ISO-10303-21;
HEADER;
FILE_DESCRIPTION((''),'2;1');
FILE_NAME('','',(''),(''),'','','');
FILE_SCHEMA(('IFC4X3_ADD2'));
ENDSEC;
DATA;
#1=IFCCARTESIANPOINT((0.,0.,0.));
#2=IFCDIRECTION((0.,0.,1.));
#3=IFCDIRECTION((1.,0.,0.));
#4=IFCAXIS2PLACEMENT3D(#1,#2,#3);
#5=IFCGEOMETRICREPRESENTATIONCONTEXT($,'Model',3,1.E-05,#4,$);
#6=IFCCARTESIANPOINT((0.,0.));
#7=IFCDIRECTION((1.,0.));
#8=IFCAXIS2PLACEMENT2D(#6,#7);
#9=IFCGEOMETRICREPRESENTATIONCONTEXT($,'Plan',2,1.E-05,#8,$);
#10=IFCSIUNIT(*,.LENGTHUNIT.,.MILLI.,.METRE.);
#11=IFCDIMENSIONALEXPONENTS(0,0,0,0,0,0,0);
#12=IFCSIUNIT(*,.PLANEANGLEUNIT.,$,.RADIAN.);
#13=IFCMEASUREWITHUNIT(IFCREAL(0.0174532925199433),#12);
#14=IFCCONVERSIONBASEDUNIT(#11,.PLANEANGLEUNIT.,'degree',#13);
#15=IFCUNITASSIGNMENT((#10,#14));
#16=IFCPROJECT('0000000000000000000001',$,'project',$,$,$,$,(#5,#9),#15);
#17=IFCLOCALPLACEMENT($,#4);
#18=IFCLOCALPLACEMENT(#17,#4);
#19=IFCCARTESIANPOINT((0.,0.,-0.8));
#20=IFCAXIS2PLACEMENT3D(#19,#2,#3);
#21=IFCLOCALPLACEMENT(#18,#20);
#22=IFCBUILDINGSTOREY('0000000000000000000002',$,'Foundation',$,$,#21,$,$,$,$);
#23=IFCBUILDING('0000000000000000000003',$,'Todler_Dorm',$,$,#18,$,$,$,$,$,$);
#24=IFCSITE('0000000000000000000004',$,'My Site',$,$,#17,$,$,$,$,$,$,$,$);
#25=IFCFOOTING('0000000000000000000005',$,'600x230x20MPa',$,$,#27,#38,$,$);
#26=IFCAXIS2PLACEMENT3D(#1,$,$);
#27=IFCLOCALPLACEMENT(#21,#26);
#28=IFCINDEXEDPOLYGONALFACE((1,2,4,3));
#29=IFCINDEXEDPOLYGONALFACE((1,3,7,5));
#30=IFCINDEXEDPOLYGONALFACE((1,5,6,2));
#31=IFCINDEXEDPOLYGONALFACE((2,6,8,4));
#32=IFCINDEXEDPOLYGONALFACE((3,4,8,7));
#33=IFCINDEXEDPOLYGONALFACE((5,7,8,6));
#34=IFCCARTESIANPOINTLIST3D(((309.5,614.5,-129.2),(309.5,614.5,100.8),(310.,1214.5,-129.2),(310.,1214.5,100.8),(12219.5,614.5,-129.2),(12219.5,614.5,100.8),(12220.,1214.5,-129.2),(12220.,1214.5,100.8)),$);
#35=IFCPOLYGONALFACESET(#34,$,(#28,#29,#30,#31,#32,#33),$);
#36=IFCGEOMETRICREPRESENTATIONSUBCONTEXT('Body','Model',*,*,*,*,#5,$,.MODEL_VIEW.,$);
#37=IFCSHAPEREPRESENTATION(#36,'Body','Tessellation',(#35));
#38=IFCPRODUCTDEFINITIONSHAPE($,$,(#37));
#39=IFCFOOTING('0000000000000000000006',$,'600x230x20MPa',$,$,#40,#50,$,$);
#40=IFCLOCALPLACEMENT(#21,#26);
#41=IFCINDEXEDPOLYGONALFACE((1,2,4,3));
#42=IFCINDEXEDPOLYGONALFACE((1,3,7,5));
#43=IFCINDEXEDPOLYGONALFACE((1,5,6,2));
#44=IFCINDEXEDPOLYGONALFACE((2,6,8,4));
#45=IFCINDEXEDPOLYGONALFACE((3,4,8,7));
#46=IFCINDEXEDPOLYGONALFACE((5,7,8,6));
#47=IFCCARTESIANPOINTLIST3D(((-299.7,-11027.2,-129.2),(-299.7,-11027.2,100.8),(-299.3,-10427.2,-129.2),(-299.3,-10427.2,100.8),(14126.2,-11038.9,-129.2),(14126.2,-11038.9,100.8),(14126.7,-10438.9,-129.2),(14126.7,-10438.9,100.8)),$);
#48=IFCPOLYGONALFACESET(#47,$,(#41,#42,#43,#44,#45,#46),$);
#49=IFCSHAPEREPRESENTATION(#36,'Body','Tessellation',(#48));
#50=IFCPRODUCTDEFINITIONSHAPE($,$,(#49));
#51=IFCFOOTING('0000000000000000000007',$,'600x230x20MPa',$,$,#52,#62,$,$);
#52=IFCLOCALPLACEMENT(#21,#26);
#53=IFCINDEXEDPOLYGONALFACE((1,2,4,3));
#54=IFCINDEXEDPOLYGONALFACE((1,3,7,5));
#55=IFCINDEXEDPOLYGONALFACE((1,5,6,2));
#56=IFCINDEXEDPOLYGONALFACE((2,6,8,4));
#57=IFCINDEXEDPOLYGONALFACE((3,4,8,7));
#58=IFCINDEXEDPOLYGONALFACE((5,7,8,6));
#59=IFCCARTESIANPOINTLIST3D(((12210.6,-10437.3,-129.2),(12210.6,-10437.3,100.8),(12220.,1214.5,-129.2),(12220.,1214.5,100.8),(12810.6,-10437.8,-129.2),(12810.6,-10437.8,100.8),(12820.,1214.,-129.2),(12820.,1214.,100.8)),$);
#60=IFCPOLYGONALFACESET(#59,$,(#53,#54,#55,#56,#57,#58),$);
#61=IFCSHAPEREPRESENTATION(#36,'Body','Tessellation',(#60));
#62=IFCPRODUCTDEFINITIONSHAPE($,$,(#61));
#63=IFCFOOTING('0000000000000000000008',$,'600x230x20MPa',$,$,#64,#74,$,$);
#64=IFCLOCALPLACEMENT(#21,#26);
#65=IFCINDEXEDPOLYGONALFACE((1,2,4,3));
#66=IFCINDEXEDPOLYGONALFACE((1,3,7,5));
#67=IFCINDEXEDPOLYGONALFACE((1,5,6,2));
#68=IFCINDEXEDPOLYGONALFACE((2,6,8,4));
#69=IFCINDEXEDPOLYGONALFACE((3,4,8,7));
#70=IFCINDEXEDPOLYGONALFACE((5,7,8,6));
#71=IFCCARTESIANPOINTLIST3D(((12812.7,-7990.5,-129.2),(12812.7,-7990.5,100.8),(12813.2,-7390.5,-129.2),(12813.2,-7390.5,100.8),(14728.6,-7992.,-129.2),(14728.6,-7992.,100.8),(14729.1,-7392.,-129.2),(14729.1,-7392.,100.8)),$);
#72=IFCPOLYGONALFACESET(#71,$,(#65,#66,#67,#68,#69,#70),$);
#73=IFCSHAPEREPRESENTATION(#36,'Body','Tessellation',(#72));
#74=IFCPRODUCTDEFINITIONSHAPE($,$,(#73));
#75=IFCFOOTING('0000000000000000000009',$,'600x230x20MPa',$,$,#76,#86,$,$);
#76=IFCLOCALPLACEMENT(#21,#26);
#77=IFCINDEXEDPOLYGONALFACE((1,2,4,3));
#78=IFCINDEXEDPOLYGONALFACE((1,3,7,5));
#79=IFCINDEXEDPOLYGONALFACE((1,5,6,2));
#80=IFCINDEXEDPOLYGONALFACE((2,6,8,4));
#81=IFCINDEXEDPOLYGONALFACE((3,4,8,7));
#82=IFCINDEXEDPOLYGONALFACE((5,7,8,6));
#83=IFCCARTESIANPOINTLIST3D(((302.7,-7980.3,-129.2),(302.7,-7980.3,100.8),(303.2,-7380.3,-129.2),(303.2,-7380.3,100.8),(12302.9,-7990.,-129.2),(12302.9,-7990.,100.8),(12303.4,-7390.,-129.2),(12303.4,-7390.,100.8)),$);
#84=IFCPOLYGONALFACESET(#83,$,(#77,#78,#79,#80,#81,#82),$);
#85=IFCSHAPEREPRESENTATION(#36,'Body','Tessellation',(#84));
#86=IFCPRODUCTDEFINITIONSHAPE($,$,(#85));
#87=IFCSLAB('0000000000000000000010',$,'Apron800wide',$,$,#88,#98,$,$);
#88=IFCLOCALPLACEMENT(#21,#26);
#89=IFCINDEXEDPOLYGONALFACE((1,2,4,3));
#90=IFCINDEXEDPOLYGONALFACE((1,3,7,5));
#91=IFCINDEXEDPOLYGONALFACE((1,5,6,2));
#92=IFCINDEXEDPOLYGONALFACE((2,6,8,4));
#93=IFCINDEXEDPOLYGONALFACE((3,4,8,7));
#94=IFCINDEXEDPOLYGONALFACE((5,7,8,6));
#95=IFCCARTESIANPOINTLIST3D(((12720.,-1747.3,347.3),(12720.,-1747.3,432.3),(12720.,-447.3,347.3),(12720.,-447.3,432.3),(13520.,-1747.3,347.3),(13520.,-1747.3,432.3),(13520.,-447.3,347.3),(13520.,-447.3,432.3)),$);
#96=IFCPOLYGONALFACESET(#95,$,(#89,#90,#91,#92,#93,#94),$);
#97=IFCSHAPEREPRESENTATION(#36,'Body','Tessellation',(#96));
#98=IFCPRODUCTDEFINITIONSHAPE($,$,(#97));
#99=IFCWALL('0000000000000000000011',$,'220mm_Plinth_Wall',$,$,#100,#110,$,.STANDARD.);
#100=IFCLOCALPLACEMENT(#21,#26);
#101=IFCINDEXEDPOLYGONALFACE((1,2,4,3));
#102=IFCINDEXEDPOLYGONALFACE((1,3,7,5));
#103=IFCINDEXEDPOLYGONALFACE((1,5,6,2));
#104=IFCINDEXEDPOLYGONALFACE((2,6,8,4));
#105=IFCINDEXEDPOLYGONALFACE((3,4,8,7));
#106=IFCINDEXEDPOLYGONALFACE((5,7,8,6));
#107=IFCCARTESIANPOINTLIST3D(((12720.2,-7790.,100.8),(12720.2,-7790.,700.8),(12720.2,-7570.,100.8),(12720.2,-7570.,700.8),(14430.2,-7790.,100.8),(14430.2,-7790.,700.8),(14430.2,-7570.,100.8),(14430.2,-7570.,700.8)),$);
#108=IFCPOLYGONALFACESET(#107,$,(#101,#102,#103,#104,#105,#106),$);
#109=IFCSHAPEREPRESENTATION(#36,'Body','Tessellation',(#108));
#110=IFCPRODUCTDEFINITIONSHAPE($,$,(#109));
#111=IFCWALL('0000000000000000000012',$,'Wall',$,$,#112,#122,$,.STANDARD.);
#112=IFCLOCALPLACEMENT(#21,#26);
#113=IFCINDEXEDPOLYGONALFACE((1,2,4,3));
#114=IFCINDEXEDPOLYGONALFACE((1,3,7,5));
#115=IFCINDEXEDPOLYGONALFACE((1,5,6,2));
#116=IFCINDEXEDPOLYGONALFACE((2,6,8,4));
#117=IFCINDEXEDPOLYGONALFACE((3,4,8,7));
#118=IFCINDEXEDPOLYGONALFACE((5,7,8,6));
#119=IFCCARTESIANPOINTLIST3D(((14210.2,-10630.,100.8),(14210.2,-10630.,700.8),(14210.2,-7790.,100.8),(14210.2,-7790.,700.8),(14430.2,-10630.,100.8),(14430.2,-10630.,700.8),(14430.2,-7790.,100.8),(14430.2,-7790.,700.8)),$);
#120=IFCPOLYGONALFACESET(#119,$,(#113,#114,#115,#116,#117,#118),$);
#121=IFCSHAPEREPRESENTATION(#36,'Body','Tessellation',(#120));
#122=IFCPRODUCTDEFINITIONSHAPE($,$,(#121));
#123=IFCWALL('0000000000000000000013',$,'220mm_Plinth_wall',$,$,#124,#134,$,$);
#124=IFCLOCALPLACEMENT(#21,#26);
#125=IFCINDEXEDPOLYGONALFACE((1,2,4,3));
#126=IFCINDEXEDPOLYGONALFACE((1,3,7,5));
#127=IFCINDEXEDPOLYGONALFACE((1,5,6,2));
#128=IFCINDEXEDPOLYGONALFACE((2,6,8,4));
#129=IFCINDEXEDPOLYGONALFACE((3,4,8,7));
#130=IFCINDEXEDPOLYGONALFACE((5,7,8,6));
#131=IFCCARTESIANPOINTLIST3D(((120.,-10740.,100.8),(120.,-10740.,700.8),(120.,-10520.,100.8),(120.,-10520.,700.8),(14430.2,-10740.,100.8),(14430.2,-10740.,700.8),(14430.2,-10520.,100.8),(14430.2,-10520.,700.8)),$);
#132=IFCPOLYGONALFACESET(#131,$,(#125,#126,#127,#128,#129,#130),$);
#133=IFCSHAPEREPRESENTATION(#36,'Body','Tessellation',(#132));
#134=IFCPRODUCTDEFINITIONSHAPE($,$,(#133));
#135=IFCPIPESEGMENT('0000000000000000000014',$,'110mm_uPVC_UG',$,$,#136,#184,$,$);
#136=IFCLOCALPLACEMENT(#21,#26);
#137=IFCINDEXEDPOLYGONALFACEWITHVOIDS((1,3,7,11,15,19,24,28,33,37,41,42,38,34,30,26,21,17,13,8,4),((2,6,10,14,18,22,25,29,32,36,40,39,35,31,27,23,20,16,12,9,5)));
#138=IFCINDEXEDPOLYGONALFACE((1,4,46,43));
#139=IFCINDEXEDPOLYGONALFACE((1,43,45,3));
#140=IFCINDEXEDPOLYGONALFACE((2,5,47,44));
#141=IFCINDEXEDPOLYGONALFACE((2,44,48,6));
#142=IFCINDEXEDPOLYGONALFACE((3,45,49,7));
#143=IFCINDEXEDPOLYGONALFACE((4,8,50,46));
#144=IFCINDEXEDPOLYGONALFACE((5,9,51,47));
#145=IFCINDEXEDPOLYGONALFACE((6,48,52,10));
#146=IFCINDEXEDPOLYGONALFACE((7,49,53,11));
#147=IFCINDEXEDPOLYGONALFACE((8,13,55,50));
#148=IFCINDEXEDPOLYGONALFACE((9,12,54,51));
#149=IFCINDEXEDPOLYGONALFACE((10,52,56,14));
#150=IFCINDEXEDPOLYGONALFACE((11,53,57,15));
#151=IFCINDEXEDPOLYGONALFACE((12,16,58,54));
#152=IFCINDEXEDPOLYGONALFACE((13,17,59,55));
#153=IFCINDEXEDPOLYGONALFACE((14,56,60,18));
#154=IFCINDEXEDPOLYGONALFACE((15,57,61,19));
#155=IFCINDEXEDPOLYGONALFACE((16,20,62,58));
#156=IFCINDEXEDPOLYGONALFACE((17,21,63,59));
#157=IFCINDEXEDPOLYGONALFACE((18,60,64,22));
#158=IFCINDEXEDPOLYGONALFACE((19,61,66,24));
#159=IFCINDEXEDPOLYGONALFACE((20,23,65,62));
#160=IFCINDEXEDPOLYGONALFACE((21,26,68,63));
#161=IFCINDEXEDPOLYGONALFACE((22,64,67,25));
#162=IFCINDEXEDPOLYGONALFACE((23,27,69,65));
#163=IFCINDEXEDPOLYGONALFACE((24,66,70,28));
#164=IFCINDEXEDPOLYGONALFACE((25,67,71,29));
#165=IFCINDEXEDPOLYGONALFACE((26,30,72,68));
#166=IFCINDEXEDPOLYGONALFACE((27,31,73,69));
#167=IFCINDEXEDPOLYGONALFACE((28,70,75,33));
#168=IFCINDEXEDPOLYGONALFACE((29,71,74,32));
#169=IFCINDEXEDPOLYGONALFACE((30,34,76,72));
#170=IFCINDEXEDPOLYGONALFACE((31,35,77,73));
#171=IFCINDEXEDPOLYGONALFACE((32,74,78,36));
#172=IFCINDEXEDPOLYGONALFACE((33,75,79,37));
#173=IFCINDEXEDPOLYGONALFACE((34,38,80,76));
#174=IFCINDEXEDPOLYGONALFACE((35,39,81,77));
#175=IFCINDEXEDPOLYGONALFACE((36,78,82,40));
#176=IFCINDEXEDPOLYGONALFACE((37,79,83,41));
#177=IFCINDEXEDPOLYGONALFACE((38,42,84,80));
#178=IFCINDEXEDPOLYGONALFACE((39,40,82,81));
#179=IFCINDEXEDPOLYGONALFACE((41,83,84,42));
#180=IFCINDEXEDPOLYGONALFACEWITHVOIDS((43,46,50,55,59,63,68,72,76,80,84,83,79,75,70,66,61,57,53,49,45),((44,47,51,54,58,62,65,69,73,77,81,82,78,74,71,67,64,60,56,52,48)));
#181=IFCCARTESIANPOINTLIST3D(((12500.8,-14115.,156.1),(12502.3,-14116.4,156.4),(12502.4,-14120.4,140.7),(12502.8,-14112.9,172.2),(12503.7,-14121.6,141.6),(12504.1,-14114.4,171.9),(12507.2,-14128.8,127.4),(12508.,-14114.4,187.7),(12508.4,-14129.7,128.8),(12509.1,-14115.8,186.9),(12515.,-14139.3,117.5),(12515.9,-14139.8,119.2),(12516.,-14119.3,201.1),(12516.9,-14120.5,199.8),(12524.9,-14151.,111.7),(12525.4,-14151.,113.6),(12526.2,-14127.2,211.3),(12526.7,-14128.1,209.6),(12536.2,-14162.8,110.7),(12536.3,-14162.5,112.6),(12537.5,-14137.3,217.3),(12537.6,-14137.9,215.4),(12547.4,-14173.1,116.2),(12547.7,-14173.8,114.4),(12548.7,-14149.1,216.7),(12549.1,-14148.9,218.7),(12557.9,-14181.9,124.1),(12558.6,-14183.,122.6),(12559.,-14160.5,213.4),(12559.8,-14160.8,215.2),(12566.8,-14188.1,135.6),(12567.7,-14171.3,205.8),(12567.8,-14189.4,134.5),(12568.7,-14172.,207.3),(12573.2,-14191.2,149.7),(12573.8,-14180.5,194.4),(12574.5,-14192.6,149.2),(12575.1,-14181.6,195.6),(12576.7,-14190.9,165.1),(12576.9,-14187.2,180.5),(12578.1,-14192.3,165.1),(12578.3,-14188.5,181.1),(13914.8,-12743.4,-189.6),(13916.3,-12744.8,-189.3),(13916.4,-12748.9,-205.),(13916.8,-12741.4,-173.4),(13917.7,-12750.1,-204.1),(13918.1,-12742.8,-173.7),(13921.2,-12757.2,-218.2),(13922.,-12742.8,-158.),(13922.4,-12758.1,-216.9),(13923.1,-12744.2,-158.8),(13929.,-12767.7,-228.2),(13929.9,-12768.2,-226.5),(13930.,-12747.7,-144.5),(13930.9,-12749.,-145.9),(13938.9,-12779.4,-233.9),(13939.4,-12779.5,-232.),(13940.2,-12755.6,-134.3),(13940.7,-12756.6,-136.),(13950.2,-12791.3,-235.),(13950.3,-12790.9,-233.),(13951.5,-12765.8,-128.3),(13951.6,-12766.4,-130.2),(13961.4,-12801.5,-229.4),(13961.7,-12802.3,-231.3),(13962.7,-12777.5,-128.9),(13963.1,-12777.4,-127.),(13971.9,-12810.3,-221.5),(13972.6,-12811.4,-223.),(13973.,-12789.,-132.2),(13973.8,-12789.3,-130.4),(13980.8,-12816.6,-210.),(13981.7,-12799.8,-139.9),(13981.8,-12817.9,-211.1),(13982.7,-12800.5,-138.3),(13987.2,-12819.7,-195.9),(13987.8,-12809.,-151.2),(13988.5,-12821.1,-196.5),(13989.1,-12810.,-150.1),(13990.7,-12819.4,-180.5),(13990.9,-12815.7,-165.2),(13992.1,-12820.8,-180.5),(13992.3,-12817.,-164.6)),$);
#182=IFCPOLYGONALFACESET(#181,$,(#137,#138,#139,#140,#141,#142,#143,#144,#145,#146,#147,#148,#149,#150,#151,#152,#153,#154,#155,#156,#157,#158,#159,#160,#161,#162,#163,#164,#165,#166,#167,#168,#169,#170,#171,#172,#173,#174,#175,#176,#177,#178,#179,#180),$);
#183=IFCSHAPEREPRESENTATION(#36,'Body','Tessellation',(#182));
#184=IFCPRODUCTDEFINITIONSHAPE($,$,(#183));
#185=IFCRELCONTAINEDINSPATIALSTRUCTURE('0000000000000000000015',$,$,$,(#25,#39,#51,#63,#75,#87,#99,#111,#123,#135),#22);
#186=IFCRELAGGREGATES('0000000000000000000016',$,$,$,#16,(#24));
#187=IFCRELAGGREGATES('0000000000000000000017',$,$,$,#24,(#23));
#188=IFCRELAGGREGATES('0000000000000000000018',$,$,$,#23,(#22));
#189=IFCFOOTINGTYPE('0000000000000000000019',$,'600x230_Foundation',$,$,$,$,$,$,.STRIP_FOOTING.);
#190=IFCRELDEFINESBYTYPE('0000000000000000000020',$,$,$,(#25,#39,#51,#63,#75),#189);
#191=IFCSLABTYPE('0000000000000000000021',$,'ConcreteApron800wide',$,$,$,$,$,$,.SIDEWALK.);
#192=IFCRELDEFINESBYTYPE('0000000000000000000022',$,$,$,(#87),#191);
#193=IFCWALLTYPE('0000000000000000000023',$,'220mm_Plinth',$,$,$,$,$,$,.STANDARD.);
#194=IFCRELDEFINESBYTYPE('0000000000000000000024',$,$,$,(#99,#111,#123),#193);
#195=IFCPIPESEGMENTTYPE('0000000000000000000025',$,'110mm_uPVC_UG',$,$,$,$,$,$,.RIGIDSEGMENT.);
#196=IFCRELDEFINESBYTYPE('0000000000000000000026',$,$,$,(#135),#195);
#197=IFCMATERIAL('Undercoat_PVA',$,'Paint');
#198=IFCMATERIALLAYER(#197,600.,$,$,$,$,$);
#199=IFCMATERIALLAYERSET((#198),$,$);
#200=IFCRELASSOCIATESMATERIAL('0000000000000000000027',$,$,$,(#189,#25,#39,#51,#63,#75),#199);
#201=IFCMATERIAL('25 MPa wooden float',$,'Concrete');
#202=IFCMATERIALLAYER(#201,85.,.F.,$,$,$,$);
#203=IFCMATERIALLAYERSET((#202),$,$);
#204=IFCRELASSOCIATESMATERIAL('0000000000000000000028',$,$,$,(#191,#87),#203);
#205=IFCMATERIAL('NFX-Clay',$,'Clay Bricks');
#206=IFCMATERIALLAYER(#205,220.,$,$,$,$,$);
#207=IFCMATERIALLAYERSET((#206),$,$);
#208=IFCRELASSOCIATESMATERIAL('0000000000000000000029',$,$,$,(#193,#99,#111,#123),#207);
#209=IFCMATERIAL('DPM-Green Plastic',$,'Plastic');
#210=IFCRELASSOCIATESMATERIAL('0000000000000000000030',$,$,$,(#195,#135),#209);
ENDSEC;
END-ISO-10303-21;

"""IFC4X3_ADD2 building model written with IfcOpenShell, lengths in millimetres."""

from ifc_helpers import new_model, entity, si_unit, converted_unit, frame, origin_with_axes, origin_2d_with_axis, place, context, subcontext, project, spatial, line, indexed_curve, hollow_circle, outline, extrude, material, layer, layer_set, layer_usage, material_profile, profile_set, profile_usage, type_object, element, save


model = new_model("IFC4X3_ADD2")

# Units and contexts
model_context = context("Model", 3, precision=1e-05, world=origin_with_axes())
plan_context = context("Plan", 2, precision=1e-05, world=origin_2d_with_axis())
body_context = subcontext(model_context, "Body", "Model", "MODEL_VIEW")
ifc_project = project(units=[si_unit("LENGTHUNIT", "METRE", prefix="MILLI"), converted_unit("PLANEANGLEUNIT", "degree", entity("IfcReal", 0.0174532925199433), si_unit("PLANEANGLEUNIT", "RADIAN"), dimensions=[0, 0, 0, 0, 0, 0, 0])], contexts=[model_context, plan_context])

# Site, building, storey
site_placement = place(None, origin_with_axes())
site = spatial("IfcSite", under=ifc_project, at=site_placement, Name="My Site")
building_placement = place(site_placement, origin_with_axes())
building = spatial("IfcBuilding", under=site, at=building_placement, Name="Todler_Dorm")
storey_placement = place(building_placement, frame((0.0, 0.0, -0.8), z_axis=(0.0, 0.0, 1.0), x_axis=(1.0, 0.0, 0.0)))
storey = spatial("IfcBuildingStorey", under=building, at=storey_placement, Name="Foundation")

# Footings
ifc_material_1 = material(Name="Undercoat_PVA", Category="Paint")
ifc_layer_1 = layer(ifc_material_1, 600.0)
ifc_layer_set_1 = layer_set([ifc_layer_1])
ifc_layer_usage_1 = layer_usage(ifc_layer_set_1, "AXIS2", "NEGATIVE", 0.0)
footing_type = type_object("IfcFootingType", Name="600x230_Foundation", PredefinedType="STRIP_FOOTING", material=ifc_layer_set_1)
footing_1_placement = place(storey_placement, frame((12219.5, 614.5, -129.2), z_axis=(0.0, 0.0, 1.0), x_axis=(-1.0, 0.0, 0.0)))
element("IfcFooting", 1, at=footing_1_placement, inside=storey, type_object=footing_type, material=ifc_layer_usage_1, Name="600x230x20MPa", context=body_context, shape_type="SweptSolid", body=[
    extrude(outline(indexed_curve([(-0.5, -600.0), (0.0, 0.0), (11910.0, 0.0), (11909.5, -600.0)], segments=[line(1, 2, 3, 4, 1)])), origin_with_axes(), (0.0, 0.0, 1.0), 230.0),
])
ifc_layer_usage_2 = layer_usage(ifc_layer_set_1, "AXIS2", "POSITIVE", 0.0)
footing_2_placement = place(storey_placement, frame((14126.7, -10438.9, -129.2), z_axis=(0.0, 0.0, 1.0), x_axis=(-1.0, 0.000807, 0.0)))
element("IfcFooting", 2, at=footing_2_placement, inside=storey, type_object=footing_type, material=ifc_layer_usage_2, Name="600x230x20MPa", context=body_context, shape_type="SweptSolid", body=[
    extrude(outline(indexed_curve([(0.0, 0.0), (0.0, 600.0), (14425.9, 600.0), (14425.9, 0.0)], segments=[line(1, 2, 3, 4, 1)])), origin_with_axes(), (0.0, 0.0, 1.0), 230.0),
])
ifc_layer_usage_3 = layer_usage(ifc_layer_set_1, "AXIS2", "POSITIVE", 0.0)
footing_3_placement = place(storey_placement, frame((12220.0, 1214.5, -129.2), z_axis=(0.0, 0.0, 1.0), x_axis=(-0.000807, -1.0, 0.0)))
element("IfcFooting", 3, at=footing_3_placement, inside=storey, type_object=footing_type, material=ifc_layer_usage_3, Name="600x230x20MPa", context=body_context, shape_type="SweptSolid", body=[
    extrude(outline(indexed_curve([(0.0, 0.0), (0.0, 600.0), (11651.8, 600.0), (11651.8, 0.0)], segments=[line(1, 2, 3, 4, 1)])), origin_with_axes(), (0.0, 0.0, 1.0), 230.0),
])
ifc_layer_usage_4 = layer_usage(ifc_layer_set_1, "AXIS2", "POSITIVE", 0.0)
footing_4_placement = place(storey_placement, frame((14729.1, -7392.0, -129.2), z_axis=(0.0, 0.0, 1.0), x_axis=(-1.0, 0.000807, 0.0)))
element("IfcFooting", 4, at=footing_4_placement, inside=storey, type_object=footing_type, material=ifc_layer_usage_4, Name="600x230x20MPa", context=body_context, shape_type="SweptSolid", body=[
    extrude(outline(indexed_curve([(0.0, 0.0), (0.0, 600.0), (1915.9, 600.0), (1915.9, 0.0)], segments=[line(1, 2, 3, 4, 1)])), origin_with_axes(), (0.0, 0.0, 1.0), 230.0),
])
ifc_layer_usage_5 = layer_usage(ifc_layer_set_1, "AXIS2", "POSITIVE", 0.0)
footing_5_placement = place(storey_placement, frame((12303.4, -7390.0, -129.2), z_axis=(0.0, 0.0, 1.0), x_axis=(-1.0, 0.000807, 0.0)))
element("IfcFooting", 5, at=footing_5_placement, inside=storey, type_object=footing_type, material=ifc_layer_usage_5, Name="600x230x20MPa", context=body_context, shape_type="SweptSolid", body=[
    extrude(outline(indexed_curve([(0.0, 0.0), (0.0, 600.0), (12000.2, 600.0), (12000.2, 0.0)], segments=[line(1, 2, 3, 4, 1)])), origin_with_axes(), (0.0, 0.0, 1.0), 230.0),
])

# Slab
ifc_material_2 = material(Name="25 MPa wooden float", Category="Concrete")
ifc_layer_2 = layer(ifc_material_2, 85.0, ventilated=False)
ifc_layer_set_2 = layer_set([ifc_layer_2])
slab_type = type_object("IfcSlabType", Name="ConcreteApron800wide", PredefinedType="SIDEWALK", material=ifc_layer_set_2)
ifc_layer_usage_6 = layer_usage(ifc_layer_set_2, "AXIS3", "POSITIVE", -100.0)
slab_1_placement = place(storey_placement, frame((12720.0, -1747.3, 447.3), z_axis=(0.0, 0.0, 1.0), x_axis=(0.000001, -1.0, 0.0)))
element("IfcSlab", 6, at=slab_1_placement, inside=storey, type_object=slab_type, material=ifc_layer_usage_6, Name="Apron800wide", context=body_context, shape_type="SweptSolid", body=[
    extrude(outline(indexed_curve([(0.0, 0.0), (0.0, 800.0), (-1300.0, 800.0), (-1300.0, 0.0), (0.0, 0.0)])), frame((0.0, 0.0, -100.0), z_axis=(0.0, 0.0, 1.0), x_axis=(1.0, 0.0, 0.0)), (0.0, 0.0, 1.0), 85.0),
])

# Walls
ifc_material_3 = material(Name="NFX-Clay", Category="Clay Bricks")
ifc_layer_3 = layer(ifc_material_3, 220.0)
ifc_layer_set_3 = layer_set([ifc_layer_3])
ifc_layer_usage_7 = layer_usage(ifc_layer_set_3, "AXIS2", "NEGATIVE", 0.0)
wall_type = type_object("IfcWallType", Name="220mm_Plinth", PredefinedType="STANDARD", material=ifc_layer_set_3)
wall_1_placement = place(storey_placement, frame((14430.2, -7790.0, 100.8), z_axis=(0.0, 0.0, 1.0), x_axis=(-1.0, 0.0, 0.0)))
element("IfcWall", 7, at=wall_1_placement, inside=storey, type_object=wall_type, material=ifc_layer_usage_7, Name="220mm_Plinth_Wall", PredefinedType="STANDARD", context=body_context, shape_type="SweptSolid", body=[
    extrude(outline(indexed_curve([(0.0, -220.0), (0.0, 0.0), (1710.0, 0.0), (1710.0, -220.0)], segments=[line(1, 2, 3, 4, 1)])), origin_with_axes(), (0.0, 0.0, 1.0), 600.0),
])
ifc_layer_usage_8 = layer_usage(ifc_layer_set_3, "AXIS2", "POSITIVE", 0.0)
wall_2_placement = place(storey_placement, frame((14210.2, -7790.0, 100.8), z_axis=(0.0, 0.0, 1.0), x_axis=(0.0, -1.0, 0.0)))
element("IfcWall", 8, at=wall_2_placement, inside=storey, type_object=wall_type, material=ifc_layer_usage_8, Name="Wall", PredefinedType="STANDARD", context=body_context, shape_type="SweptSolid", body=[
    extrude(outline(indexed_curve([(0.0, 0.0), (0.0, 220.0), (2840.0, 220.0), (2840.0, 0.0)], segments=[line(1, 2, 3, 4, 1)])), origin_with_axes(), (0.0, 0.0, 1.0), 600.0),
])
ifc_layer_usage_9 = layer_usage(ifc_layer_set_3, "AXIS2", "NEGATIVE", 0.0)
wall_3_placement = place(storey_placement, frame((14430.2, -10740.0, 100.8), z_axis=(0.0, 0.0, 1.0), x_axis=(-1.0, 0.0, 0.0)))
element("IfcWall", 9, at=wall_3_placement, inside=storey, type_object=wall_type, material=ifc_layer_usage_9, Name="220mm_Plinth_wall", context=body_context, shape_type="SweptSolid", body=[
    extrude(outline(indexed_curve([(0.0, -220.0), (0.0, 0.0), (14310.2, 0.0), (14310.2, -220.0)], segments=[line(1, 2, 3, 4, 1)])), origin_with_axes(), (0.0, 0.0, 1.0), 600.0),
])

# Pipe segment
ifc_material_4 = material(Name="DPM-Green Plastic", Category="Plastic")
ifc_material_profile = material_profile(ifc_material_4, hollow_circle(Radius=55.0, WallThickness=2.0))
ifc_profile_set = profile_set([ifc_material_profile])
ifc_profile_usage = profile_usage(ifc_profile_set, cardinal=5)
pipe_segment_type = type_object("IfcPipeSegmentType", Name="110mm_uPVC_UG", PredefinedType="RIGIDSEGMENT", material=ifc_profile_set)
pipe_segment_placement = place(storey_placement, frame((12539.7, -14152.9, 164.6), z_axis=(0.706999, 0.685772, -0.172825), x_axis=(-0.707107, 0.689724, -0.155826)))
element("IfcPipeSegment", 10, at=pipe_segment_placement, inside=storey, type_object=pipe_segment_type, material=ifc_profile_usage, Name="110mm_uPVC_UG", context=body_context, shape_type="SweptSolid", body=[
    extrude(hollow_circle(Radius=55.0, WallThickness=2.0), origin_with_axes(), (0.0, 0.0, 1.0), 2000.0),
])

save(model, "model.ifc")
